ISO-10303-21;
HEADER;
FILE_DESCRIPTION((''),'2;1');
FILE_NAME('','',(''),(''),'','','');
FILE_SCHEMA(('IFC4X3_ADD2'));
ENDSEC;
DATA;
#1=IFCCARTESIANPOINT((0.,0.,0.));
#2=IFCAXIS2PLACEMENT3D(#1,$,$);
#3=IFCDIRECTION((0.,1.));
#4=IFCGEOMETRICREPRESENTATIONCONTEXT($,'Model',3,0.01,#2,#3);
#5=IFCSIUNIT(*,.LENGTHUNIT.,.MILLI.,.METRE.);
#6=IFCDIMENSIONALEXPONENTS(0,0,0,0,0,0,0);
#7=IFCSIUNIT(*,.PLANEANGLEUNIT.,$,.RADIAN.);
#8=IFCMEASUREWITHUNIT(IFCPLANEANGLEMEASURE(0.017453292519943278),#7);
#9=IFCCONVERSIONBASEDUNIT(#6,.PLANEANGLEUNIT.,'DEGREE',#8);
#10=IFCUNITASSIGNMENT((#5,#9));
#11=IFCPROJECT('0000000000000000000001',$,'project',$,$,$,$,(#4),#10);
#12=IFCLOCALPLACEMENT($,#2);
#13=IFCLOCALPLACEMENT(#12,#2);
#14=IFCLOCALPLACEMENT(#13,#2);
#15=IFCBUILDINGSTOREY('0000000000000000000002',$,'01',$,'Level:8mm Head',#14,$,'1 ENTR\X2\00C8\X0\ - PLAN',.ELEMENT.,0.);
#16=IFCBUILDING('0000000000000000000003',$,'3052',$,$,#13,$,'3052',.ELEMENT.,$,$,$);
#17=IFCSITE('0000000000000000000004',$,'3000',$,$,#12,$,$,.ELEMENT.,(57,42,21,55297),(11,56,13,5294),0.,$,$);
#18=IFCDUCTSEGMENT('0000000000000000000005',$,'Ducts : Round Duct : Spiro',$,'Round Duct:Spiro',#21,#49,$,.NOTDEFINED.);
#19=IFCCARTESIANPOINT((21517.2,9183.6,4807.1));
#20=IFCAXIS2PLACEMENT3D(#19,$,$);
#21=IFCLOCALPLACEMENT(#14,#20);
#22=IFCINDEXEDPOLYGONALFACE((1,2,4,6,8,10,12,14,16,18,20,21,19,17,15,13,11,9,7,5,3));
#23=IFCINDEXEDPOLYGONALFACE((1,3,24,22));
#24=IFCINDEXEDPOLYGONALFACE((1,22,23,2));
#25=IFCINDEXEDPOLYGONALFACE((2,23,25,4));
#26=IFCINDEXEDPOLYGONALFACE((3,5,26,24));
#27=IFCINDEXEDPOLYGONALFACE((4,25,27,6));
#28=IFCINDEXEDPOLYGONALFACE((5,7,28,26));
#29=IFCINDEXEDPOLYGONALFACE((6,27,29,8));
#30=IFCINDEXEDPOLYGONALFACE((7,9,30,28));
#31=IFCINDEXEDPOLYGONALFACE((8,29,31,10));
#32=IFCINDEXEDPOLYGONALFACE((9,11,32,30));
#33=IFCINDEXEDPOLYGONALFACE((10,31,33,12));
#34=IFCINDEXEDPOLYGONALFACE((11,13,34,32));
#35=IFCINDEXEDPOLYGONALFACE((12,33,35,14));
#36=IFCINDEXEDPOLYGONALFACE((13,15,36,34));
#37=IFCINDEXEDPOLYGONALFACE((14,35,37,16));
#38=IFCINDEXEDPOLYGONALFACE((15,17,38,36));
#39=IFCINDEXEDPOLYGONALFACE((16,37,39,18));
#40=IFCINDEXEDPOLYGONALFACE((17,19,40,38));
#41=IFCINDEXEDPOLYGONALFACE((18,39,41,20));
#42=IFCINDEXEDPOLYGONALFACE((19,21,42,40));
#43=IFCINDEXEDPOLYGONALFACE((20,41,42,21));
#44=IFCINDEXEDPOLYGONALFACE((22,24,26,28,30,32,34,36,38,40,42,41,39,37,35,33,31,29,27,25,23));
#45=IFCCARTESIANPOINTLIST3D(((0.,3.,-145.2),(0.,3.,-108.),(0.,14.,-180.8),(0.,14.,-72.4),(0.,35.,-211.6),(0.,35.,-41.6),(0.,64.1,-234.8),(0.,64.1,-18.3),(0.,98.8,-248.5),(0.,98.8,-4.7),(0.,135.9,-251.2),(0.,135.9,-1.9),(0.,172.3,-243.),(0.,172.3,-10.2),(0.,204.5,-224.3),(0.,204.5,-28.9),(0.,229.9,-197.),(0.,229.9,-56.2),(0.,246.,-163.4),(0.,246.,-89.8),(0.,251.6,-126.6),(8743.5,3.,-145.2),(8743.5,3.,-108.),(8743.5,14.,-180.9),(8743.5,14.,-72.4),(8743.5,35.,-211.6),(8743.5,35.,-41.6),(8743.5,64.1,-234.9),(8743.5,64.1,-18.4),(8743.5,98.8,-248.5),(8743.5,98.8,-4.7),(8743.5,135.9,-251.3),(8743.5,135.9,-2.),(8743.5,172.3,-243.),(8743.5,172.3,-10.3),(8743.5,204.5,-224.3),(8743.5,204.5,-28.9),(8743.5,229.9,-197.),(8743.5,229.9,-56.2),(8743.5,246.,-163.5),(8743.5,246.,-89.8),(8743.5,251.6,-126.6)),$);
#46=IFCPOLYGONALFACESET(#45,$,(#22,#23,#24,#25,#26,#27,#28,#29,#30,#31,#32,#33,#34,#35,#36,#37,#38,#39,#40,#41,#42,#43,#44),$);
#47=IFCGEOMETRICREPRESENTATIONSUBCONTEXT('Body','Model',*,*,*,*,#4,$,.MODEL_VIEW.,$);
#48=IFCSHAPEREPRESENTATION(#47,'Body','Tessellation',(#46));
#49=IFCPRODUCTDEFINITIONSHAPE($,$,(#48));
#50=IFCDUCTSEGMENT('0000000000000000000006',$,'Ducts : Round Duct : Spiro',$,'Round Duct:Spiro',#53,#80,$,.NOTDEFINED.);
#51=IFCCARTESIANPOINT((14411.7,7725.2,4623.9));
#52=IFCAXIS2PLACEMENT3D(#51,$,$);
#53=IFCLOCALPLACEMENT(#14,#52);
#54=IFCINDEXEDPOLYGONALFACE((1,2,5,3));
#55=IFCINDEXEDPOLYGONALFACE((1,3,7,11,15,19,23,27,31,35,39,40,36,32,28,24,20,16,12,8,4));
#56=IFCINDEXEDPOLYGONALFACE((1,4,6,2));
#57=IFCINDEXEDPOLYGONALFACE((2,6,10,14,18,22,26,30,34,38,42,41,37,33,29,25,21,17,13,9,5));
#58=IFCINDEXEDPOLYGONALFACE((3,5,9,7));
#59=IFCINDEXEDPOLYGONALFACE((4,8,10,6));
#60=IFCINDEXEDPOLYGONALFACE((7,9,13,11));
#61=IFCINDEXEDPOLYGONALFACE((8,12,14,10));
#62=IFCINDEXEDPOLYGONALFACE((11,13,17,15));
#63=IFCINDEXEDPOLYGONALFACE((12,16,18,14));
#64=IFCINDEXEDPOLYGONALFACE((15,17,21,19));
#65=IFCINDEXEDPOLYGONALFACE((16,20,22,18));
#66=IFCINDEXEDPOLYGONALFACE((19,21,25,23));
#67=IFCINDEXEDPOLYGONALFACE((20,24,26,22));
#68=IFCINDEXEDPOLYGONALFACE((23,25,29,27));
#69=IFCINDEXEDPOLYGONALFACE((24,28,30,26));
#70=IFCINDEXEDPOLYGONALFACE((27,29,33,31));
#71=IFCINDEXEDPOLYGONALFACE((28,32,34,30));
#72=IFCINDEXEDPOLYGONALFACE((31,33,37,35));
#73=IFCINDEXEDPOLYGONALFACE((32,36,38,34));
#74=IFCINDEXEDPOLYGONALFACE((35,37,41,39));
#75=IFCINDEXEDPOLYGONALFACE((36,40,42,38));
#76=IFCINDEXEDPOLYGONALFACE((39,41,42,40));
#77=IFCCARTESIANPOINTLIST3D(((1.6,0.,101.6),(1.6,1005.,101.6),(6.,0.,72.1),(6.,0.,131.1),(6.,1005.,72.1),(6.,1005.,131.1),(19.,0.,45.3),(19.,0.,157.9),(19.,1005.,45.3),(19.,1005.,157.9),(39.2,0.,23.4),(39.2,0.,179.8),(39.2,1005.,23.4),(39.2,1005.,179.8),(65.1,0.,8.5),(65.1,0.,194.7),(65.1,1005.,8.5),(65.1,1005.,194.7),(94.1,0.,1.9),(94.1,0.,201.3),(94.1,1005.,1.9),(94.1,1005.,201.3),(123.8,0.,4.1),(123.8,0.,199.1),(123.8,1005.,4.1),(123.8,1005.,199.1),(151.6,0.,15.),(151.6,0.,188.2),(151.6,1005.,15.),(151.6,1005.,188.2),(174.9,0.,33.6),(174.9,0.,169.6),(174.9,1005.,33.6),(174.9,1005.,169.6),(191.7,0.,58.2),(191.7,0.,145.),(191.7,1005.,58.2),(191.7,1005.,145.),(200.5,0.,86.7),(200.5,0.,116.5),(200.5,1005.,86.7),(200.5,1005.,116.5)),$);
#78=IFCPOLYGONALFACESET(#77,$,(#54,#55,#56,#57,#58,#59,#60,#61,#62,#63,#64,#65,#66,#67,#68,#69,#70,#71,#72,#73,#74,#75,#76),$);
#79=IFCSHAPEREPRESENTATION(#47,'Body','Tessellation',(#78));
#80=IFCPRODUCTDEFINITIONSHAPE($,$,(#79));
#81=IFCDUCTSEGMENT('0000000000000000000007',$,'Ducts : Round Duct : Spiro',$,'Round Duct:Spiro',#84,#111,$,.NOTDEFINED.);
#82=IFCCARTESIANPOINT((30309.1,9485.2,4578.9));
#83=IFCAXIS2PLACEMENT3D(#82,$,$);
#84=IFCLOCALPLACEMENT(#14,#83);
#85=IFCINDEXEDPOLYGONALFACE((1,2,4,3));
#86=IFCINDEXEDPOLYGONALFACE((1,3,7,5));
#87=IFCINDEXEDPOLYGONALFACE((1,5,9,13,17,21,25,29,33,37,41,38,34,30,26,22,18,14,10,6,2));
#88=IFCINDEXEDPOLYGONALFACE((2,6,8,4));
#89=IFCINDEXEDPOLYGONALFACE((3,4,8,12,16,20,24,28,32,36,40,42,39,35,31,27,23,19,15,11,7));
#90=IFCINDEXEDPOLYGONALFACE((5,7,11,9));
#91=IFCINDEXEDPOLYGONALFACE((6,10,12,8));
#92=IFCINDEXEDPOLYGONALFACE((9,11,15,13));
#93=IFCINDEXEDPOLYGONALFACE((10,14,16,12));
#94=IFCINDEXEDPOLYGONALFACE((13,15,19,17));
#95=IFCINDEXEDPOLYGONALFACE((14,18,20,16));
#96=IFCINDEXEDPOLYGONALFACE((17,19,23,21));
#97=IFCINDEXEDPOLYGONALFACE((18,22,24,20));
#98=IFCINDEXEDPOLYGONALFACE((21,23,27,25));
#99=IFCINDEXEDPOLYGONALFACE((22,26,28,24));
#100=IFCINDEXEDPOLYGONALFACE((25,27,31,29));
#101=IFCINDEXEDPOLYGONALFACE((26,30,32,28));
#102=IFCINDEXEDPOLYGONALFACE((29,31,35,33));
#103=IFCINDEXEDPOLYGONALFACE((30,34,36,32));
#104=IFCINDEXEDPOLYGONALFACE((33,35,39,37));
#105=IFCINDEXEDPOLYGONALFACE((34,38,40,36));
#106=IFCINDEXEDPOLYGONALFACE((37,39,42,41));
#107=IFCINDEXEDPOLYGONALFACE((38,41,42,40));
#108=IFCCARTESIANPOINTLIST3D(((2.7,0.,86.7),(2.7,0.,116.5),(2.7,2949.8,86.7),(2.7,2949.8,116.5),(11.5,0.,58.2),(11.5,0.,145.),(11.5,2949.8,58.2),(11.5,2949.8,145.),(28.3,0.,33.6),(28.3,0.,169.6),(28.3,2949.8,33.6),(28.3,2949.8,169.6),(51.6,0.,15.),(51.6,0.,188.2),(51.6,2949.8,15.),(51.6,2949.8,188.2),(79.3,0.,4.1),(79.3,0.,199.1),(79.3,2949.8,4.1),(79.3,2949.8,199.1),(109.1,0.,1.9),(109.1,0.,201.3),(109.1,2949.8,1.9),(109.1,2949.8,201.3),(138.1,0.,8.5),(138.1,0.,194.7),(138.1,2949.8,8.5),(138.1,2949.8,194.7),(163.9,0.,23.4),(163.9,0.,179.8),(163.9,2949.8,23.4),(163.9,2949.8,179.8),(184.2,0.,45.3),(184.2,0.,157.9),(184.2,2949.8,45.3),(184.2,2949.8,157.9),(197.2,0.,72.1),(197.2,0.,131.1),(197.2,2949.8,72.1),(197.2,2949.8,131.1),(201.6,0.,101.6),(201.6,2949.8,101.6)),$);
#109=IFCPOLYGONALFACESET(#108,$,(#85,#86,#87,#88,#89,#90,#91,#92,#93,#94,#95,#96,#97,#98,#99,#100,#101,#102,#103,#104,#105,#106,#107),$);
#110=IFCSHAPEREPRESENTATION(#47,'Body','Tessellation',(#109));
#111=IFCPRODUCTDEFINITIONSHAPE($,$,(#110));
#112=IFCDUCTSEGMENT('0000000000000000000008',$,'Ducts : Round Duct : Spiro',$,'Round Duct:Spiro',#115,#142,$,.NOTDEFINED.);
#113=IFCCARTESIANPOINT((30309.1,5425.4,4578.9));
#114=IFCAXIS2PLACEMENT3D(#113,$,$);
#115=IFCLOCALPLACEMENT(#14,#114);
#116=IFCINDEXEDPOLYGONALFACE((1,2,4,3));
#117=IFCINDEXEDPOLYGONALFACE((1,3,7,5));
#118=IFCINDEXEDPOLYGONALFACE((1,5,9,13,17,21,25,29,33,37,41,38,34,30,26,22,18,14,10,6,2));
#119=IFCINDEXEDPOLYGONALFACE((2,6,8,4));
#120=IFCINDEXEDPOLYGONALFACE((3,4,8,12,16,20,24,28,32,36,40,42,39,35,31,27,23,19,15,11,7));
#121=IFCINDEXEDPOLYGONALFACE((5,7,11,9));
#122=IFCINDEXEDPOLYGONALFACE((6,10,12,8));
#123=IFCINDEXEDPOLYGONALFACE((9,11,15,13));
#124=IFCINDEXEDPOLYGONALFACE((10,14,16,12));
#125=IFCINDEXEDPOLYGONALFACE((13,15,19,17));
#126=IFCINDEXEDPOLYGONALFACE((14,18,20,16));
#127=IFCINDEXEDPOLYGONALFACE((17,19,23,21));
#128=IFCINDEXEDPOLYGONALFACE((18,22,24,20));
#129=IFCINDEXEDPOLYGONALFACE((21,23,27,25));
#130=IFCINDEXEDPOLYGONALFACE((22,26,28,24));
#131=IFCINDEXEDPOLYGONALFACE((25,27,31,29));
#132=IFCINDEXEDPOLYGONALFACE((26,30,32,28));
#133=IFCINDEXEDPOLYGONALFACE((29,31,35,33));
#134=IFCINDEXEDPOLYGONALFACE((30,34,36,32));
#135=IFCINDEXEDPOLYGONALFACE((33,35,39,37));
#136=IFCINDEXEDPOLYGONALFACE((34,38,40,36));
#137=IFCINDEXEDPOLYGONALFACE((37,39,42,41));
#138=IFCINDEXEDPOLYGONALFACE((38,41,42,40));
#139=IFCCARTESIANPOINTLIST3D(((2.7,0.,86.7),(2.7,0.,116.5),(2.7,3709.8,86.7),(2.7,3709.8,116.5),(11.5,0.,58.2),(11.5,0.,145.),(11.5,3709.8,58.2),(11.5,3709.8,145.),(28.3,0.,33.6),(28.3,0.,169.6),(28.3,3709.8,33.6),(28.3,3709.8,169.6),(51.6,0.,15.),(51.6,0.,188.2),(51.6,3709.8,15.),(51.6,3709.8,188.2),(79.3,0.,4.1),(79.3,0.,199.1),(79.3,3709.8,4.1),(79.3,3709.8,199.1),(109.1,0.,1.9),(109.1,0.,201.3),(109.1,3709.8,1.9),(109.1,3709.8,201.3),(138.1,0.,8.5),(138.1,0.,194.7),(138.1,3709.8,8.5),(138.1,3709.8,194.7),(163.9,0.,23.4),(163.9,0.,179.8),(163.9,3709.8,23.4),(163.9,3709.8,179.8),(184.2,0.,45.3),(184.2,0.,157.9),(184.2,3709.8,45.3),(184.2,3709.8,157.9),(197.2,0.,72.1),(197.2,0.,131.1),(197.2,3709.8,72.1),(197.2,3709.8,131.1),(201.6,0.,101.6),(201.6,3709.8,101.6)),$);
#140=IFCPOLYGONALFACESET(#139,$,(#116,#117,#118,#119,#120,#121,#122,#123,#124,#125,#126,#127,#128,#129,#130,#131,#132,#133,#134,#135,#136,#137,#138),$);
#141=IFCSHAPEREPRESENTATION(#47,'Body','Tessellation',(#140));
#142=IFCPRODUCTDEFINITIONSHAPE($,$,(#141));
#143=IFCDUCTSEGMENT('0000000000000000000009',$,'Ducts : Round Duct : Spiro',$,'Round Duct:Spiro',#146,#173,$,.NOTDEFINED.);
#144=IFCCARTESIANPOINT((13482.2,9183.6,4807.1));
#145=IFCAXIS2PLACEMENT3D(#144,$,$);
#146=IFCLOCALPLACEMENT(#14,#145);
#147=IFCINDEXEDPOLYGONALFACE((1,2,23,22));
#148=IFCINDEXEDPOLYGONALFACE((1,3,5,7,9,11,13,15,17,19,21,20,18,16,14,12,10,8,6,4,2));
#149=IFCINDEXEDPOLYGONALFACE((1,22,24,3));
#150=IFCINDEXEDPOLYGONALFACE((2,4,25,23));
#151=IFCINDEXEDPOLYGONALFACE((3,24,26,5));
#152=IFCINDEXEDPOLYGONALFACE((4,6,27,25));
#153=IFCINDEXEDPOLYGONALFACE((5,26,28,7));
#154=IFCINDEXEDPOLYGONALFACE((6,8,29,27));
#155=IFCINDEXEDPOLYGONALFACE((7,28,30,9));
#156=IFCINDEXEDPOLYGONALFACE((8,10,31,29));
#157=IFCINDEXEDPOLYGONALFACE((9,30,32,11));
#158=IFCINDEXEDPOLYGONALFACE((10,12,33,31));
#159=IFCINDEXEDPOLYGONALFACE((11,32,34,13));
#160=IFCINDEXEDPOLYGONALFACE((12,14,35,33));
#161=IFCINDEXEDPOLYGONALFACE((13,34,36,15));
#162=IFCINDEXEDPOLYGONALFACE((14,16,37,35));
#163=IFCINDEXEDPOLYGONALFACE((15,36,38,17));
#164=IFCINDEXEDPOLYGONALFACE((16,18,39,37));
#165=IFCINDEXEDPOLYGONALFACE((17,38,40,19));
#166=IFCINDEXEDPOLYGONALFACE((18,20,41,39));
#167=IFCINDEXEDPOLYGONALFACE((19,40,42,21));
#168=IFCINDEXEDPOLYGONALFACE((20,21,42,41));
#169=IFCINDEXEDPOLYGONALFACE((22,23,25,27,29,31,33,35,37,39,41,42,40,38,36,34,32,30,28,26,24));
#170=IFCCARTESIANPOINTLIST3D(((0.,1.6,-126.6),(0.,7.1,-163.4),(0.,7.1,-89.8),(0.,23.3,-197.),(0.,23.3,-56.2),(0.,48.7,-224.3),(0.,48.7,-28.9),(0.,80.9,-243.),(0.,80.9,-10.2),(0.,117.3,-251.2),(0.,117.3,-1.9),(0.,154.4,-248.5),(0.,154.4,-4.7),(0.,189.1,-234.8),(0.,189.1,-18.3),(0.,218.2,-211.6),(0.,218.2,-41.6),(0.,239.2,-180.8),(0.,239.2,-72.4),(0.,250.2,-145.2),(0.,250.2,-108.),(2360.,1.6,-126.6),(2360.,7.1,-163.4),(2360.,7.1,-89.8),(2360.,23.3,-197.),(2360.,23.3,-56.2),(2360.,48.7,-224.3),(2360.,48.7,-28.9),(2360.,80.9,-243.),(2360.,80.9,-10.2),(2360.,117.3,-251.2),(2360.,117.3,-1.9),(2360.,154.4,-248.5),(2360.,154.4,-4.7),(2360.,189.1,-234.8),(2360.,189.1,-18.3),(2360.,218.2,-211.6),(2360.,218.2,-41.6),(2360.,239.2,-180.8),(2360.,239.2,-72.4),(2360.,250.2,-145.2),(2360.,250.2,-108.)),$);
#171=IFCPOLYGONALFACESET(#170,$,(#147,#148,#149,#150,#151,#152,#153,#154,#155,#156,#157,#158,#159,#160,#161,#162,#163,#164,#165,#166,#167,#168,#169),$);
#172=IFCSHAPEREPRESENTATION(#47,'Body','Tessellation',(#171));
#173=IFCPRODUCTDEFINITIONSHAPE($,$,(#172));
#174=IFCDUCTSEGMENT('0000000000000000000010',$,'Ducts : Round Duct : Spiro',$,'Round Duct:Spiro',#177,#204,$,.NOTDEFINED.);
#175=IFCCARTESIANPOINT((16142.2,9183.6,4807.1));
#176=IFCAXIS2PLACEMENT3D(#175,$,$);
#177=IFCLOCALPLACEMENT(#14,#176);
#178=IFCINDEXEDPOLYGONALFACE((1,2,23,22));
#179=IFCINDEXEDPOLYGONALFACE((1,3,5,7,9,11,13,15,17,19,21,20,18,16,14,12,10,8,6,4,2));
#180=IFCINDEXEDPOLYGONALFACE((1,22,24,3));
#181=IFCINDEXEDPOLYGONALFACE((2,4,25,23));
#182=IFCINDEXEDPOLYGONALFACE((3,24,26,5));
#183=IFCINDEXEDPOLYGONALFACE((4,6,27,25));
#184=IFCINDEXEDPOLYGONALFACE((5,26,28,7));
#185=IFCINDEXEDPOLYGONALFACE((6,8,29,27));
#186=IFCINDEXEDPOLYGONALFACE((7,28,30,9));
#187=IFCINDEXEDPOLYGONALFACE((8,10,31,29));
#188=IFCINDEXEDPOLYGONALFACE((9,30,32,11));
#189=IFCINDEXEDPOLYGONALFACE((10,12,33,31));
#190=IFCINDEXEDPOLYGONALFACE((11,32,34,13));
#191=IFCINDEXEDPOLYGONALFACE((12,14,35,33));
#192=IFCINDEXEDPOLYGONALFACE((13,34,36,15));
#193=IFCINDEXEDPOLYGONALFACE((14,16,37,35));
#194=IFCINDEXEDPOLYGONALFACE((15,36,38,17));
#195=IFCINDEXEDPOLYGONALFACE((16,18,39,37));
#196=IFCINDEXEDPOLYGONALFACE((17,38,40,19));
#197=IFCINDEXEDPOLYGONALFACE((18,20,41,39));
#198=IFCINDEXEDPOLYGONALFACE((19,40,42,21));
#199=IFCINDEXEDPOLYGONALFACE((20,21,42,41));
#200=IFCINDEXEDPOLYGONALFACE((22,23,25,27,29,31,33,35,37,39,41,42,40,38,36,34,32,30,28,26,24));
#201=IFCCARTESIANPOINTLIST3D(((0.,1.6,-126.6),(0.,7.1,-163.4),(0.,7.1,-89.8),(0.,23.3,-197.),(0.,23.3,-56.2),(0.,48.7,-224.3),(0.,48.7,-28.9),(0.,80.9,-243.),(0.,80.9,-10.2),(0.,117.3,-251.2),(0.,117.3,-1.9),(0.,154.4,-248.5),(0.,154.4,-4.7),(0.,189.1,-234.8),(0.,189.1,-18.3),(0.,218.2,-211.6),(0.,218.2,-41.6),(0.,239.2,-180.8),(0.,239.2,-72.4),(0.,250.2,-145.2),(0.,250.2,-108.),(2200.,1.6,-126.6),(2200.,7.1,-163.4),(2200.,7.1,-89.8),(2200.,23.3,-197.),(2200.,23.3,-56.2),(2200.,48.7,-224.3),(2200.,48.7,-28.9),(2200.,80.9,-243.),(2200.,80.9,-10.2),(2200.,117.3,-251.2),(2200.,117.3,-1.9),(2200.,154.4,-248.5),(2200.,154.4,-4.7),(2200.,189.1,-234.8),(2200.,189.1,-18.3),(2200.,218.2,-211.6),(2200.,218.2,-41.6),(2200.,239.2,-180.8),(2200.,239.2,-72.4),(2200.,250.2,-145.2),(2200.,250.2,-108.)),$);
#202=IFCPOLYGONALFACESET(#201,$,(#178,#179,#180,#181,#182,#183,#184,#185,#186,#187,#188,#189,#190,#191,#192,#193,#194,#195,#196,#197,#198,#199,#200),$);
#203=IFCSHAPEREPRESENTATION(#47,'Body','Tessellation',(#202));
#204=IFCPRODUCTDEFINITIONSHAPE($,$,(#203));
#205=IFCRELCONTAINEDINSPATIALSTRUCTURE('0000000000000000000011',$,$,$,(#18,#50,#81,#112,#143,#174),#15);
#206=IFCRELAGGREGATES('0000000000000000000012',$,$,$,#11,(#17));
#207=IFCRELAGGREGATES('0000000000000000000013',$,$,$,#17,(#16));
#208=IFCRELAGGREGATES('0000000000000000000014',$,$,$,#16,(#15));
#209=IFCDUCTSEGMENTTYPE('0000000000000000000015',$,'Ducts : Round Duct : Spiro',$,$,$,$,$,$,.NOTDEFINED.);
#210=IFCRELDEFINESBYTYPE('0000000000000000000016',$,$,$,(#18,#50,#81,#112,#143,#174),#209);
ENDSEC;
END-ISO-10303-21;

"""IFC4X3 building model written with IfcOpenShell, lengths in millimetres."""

from ifc_helpers import new_model, entity, si_unit, converted_unit, direction, frame, frame_2d, origin, origin_2d_with_axis, place, context, subcontext, project, spatial, circle, extrude, type_object, element, save


model = new_model("IFC4X3")

# Units and contexts
model_context = context("Model", 3, precision=0.01, world=origin(), true_north=direction((0.0, 1.0)))
body_context = subcontext(model_context, "Body", "Model", "MODEL_VIEW")
ifc_project = project(units=[si_unit("LENGTHUNIT", "METRE", prefix="MILLI"), converted_unit("PLANEANGLEUNIT", "DEGREE", entity("IfcPlaneAngleMeasure", 0.017453292519943278), si_unit("PLANEANGLEUNIT", "RADIAN"), dimensions=[0, 0, 0, 0, 0, 0, 0])], contexts=[model_context])

# Site, building, storey
site_placement = place(None, origin())
site = spatial("IfcSite", under=ifc_project, at=site_placement, Name="3000", CompositionType="ELEMENT", RefLatitude=(57, 42, 21, 55297), RefLongitude=(11, 56, 13, 5294), RefElevation=0.0)
building_placement = place(site_placement, origin())
building = spatial("IfcBuilding", under=site, at=building_placement, Name="3052", LongName="3052", CompositionType="ELEMENT")
storey_placement = place(building_placement, origin())
storey = spatial("IfcBuildingStorey", under=building, at=storey_placement, Name="01", ObjectType="Level:8mm Head", LongName="1 ENTRÈ - PLAN", CompositionType="ELEMENT", Elevation=0.0)

# Duct segments
duct_segment_type = type_object("IfcDuctSegmentType", Name="Ducts : Round Duct : Spiro", PredefinedType="NOTDEFINED")
duct_segment_1_placement = place(storey_placement, frame((21517.2, 9183.6, 4807.1)))
element("IfcDuctSegment", 1, at=duct_segment_1_placement, inside=storey, type_object=duct_segment_type, Name="Ducts : Round Duct : Spiro", ObjectType="Round Duct:Spiro", PredefinedType="NOTDEFINED", context=body_context, shape_type="SweptSolid", body=[
    extrude(circle(Radius=125.0, at=frame_2d((0.0, 0.0), x_axis=(1.0, 0.0))), frame((0.0, 126.6, -126.6), z_axis=(1.0, 0.0, -0.000002), x_axis=(0.0, 1.0, 0.0)), (0.0, 0.0, 1.0), 8743.5),
])
duct_segment_2_placement = place(storey_placement, frame((14411.7, 7725.2, 4623.9)))
element("IfcDuctSegment", 2, at=duct_segment_2_placement, inside=storey, type_object=duct_segment_type, Name="Ducts : Round Duct : Spiro", ObjectType="Round Duct:Spiro", PredefinedType="NOTDEFINED", context=body_context, shape_type="SweptSolid", body=[
    extrude(circle(Radius=100.0, at=origin_2d_with_axis()), frame((101.6, 0.0, 101.6), z_axis=(0.0, 1.0, 0.0), x_axis=(-1.0, 0.0, 0.0)), (0.0, 0.0, 1.0), 1005.0),
])
duct_segment_3_placement = place(storey_placement, frame((30309.1, 9485.2, 4578.9)))
element("IfcDuctSegment", 3, at=duct_segment_3_placement, inside=storey, type_object=duct_segment_type, Name="Ducts : Round Duct : Spiro", ObjectType="Round Duct:Spiro", PredefinedType="NOTDEFINED", context=body_context, shape_type="SweptSolid", body=[
    extrude(circle(Radius=100.0, at=origin_2d_with_axis()), frame((101.6, 0.0, 101.6), z_axis=(0.0, 1.0, 0.0), x_axis=(1.0, 0.0, 0.0)), (0.0, 0.0, 1.0), 2949.8),
])
duct_segment_4_placement = place(storey_placement, frame((30309.1, 5425.4, 4578.9)))
element("IfcDuctSegment", 4, at=duct_segment_4_placement, inside=storey, type_object=duct_segment_type, Name="Ducts : Round Duct : Spiro", ObjectType="Round Duct:Spiro", PredefinedType="NOTDEFINED", context=body_context, shape_type="SweptSolid", body=[
    extrude(circle(Radius=100.0, at=origin_2d_with_axis()), frame((101.6, 0.0, 101.6), z_axis=(0.0, 1.0, 0.0), x_axis=(1.0, 0.0, 0.0)), (0.0, 0.0, 1.0), 3709.8),
])
duct_segment_5_placement = place(storey_placement, frame((13482.2, 9183.6, 4807.1)))
element("IfcDuctSegment", 5, at=duct_segment_5_placement, inside=storey, type_object=duct_segment_type, Name="Ducts : Round Duct : Spiro", ObjectType="Round Duct:Spiro", PredefinedType="NOTDEFINED", context=body_context, shape_type="SweptSolid", body=[
    extrude(circle(Radius=125.0, at=frame_2d((0.0, 0.0), x_axis=(1.0, 0.0))), frame((0.0, 126.6, -126.6), z_axis=(1.0, 0.0, 0.0), x_axis=(0.0, -1.0, 0.0)), (0.0, 0.0, 1.0), 2360.0),
])
duct_segment_6_placement = place(storey_placement, frame((16142.2, 9183.6, 4807.1)))
element("IfcDuctSegment", 6, at=duct_segment_6_placement, inside=storey, type_object=duct_segment_type, Name="Ducts : Round Duct : Spiro", ObjectType="Round Duct:Spiro", PredefinedType="NOTDEFINED", context=body_context, shape_type="SweptSolid", body=[
    extrude(circle(Radius=125.0, at=frame_2d((0.0, 0.0), x_axis=(1.0, 0.0))), frame((0.0, 126.6, -126.6), z_axis=(1.0, 0.0, 0.0), x_axis=(0.0, -1.0, 0.0)), (0.0, 0.0, 1.0), 2200.0),
])

save(model, "model.ifc")
